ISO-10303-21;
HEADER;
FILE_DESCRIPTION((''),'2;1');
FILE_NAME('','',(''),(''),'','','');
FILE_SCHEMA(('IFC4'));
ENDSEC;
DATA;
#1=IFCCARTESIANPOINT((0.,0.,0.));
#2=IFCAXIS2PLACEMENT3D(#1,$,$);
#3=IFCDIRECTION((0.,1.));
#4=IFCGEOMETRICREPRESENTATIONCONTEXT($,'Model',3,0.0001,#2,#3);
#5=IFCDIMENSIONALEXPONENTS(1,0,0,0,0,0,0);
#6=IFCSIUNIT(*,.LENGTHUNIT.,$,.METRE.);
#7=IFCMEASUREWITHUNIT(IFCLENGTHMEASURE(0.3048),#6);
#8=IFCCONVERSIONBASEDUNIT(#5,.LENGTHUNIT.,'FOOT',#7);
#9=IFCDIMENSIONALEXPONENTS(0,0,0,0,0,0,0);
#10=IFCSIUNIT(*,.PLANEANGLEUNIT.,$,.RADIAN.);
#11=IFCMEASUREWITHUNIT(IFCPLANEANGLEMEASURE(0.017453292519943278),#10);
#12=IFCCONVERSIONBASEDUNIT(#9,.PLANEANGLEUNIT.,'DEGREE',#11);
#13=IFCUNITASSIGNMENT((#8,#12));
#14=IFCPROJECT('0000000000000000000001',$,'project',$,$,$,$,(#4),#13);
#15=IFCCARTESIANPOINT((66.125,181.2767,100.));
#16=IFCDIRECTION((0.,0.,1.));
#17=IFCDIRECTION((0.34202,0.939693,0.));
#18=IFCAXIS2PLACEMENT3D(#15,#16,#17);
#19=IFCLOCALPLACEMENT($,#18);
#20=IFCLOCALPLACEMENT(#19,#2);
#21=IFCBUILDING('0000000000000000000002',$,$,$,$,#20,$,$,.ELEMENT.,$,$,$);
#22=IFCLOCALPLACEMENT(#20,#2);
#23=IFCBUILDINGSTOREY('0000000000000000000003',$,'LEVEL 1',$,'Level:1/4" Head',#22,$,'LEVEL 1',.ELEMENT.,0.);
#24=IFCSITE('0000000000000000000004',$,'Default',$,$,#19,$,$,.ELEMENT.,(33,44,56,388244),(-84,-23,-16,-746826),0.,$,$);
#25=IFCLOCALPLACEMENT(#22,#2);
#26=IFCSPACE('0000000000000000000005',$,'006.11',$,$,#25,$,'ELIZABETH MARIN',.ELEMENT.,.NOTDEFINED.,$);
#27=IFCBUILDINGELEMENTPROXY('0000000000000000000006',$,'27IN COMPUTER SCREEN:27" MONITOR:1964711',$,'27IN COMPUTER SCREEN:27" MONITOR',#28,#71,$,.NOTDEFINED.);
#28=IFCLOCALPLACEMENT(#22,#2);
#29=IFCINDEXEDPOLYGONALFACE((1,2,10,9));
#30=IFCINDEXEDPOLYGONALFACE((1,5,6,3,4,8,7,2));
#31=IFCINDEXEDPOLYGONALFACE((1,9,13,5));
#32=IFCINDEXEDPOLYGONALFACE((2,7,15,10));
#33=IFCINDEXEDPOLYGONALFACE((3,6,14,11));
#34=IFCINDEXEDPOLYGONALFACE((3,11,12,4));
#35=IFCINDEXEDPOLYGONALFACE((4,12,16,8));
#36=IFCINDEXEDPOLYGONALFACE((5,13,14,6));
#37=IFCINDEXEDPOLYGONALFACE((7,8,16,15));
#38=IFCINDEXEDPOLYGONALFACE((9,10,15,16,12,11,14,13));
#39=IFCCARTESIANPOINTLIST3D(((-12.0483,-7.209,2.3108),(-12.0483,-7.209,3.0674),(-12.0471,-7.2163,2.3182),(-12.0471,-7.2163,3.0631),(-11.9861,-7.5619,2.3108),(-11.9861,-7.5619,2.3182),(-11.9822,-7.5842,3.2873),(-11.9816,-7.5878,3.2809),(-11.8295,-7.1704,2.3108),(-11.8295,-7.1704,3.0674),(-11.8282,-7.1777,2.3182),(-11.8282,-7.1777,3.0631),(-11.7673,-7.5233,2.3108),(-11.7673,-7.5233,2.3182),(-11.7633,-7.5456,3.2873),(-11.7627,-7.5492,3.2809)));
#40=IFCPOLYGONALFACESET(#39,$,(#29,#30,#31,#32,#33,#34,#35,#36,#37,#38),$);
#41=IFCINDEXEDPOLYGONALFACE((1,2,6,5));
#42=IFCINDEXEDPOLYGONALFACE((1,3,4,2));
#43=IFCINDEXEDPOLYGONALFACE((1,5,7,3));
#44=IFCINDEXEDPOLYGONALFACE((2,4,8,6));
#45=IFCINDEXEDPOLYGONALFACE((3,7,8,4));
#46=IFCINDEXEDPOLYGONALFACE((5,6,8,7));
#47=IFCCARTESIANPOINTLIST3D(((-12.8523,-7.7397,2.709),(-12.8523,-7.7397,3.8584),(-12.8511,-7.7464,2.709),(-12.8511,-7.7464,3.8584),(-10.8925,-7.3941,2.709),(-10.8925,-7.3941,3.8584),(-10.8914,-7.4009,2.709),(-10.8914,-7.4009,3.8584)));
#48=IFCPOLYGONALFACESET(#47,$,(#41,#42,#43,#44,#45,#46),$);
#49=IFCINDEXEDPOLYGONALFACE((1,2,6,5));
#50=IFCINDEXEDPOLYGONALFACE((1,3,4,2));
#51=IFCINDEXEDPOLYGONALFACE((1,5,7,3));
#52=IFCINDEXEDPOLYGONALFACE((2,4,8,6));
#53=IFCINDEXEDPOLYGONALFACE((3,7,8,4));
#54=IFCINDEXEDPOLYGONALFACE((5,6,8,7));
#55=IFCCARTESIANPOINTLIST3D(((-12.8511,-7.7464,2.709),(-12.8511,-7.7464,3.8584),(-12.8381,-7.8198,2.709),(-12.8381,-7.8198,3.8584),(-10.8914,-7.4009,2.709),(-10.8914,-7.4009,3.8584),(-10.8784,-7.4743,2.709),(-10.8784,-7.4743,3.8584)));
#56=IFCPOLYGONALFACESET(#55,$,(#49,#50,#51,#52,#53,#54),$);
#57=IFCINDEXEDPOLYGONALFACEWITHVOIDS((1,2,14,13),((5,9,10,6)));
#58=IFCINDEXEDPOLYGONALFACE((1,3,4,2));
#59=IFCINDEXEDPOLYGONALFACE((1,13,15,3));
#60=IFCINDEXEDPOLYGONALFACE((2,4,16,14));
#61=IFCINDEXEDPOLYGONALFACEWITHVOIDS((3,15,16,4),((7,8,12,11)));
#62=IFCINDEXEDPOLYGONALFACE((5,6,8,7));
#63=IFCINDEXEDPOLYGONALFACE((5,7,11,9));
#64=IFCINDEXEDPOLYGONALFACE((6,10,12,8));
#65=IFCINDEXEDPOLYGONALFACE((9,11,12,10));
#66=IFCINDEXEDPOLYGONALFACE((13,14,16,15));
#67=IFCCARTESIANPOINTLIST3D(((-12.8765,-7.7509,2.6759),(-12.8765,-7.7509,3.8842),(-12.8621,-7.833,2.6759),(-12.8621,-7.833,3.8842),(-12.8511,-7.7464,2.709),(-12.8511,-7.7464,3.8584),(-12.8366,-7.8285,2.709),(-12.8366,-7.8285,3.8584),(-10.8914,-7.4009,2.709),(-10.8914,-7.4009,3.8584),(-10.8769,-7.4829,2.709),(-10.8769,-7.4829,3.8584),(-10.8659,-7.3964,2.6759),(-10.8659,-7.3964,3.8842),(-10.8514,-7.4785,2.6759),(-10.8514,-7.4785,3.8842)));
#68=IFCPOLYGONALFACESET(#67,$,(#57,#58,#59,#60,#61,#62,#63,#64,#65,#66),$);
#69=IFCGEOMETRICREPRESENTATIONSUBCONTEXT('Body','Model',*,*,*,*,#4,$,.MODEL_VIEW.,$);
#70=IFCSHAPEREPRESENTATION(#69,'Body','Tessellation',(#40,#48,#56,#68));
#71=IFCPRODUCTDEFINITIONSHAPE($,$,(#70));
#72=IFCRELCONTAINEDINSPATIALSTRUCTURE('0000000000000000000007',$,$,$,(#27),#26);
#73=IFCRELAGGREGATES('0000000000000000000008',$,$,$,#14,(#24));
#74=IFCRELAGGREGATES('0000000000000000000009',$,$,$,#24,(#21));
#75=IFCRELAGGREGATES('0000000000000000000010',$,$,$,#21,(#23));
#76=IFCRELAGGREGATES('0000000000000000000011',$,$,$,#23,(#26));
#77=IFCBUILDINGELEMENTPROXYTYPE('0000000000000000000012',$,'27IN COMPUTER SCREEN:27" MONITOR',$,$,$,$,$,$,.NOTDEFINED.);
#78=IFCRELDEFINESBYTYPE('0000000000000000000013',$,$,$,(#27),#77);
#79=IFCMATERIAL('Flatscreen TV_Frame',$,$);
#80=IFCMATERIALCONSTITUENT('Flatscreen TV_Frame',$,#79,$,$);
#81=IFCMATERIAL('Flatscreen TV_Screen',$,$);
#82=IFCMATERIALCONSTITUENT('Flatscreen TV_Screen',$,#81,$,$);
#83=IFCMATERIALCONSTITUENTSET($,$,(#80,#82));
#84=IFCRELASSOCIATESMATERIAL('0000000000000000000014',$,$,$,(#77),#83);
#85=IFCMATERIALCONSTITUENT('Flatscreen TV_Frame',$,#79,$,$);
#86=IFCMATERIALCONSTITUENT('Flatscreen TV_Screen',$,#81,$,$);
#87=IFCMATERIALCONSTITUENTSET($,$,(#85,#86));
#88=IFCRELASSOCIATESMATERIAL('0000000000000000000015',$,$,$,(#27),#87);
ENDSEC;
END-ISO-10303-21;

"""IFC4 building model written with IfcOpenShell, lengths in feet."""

from ifc_helpers import new_model, entity, si_unit, converted_unit, direction, frame, frame_2d, origin, origin_2d_with_axis, place, context, subcontext, project, spatial, polyline, rectangle, outline, extrude, source, transform, mapped, material, constituent, constituent_set, type_object, type_shapes, element, save


model = new_model("IFC4")

# Units and contexts
model_context = context("Model", 3, precision=0.0001, world=origin(), true_north=direction((0.0, 1.0)))
body_context = subcontext(model_context, "Body", "Model", "MODEL_VIEW")
ifc_project = project(units=[converted_unit("LENGTHUNIT", "FOOT", entity("IfcLengthMeasure", 0.3048), si_unit("LENGTHUNIT", "METRE"), dimensions=[1, 0, 0, 0, 0, 0, 0]), converted_unit("PLANEANGLEUNIT", "DEGREE", entity("IfcPlaneAngleMeasure", 0.017453292519943278), si_unit("PLANEANGLEUNIT", "RADIAN"), dimensions=[0, 0, 0, 0, 0, 0, 0])], contexts=[model_context])

# Site, building, storey
site_placement = place(None, frame((66.125, 181.2767, 100.0), z_axis=(0.0, 0.0, 1.0), x_axis=(0.34202, 0.939693, 0.0)))
site = spatial("IfcSite", under=ifc_project, at=site_placement, Name="Default", CompositionType="ELEMENT", RefLatitude=(33, 44, 56, 388244), RefLongitude=(-84, -23, -16, -746826), RefElevation=0.0)
building_placement = place(site_placement, origin())
building = spatial("IfcBuilding", under=site, at=building_placement, CompositionType="ELEMENT")
storey_placement = place(building_placement, origin())
storey = spatial("IfcBuildingStorey", under=building, at=storey_placement, Name="LEVEL 1", ObjectType="Level:1/4\" Head", LongName="LEVEL 1", CompositionType="ELEMENT", Elevation=0.0)

# Shared definitions
space_placement = place(storey_placement, origin())
space = spatial("IfcSpace", under=storey, at=space_placement, Name="006.11", LongName="ELIZABETH MARIN", CompositionType="ELEMENT", PredefinedType="NOTDEFINED")

# Building element proxy
ifc_material_1 = material(Name="Flatscreen TV_Frame")
ifc_constituent_1 = constituent(ifc_material_1, Name="Flatscreen TV_Frame")
ifc_material_2 = material(Name="Flatscreen TV_Screen")
ifc_constituent_2 = constituent(ifc_material_2, Name="Flatscreen TV_Screen")
ifc_constituent_set_1 = constituent_set(constituents=[ifc_constituent_1, ifc_constituent_2])
ifc_constituent_3 = constituent(ifc_material_1, Name="Flatscreen TV_Frame")
ifc_constituent_4 = constituent(ifc_material_2, Name="Flatscreen TV_Screen")
ifc_constituent_set_2 = constituent_set(constituents=[ifc_constituent_3, ifc_constituent_4])
building_element_proxy_type = type_object("IfcBuildingElementProxyType", Name="27IN COMPUTER SCREEN:27\" MONITOR", PredefinedType="NOTDEFINED", material=ifc_constituent_set_2)
shared_shape_1 = source(origin(), body_context, "Body", "SweptSolid", [
    extrude(outline(polyline([(0.3657, -0.4392), (0.3731, -0.4392), (0.3731, 0.0007), (-0.2821, 0.379), (-0.4613, 0.0686), (-0.4548, 0.0649), (-0.2794, 0.3688), (0.3657, -0.0036), (0.3657, -0.4392)])), frame((-0.1111, 0.0264, 0.0687), z_axis=(1.0, 0.0, 0.0), x_axis=(0.0, -0.5, 0.866025)), (0.0, 0.0, 1.0), 0.2222),
    extrude(rectangle(XDim=1.9899, YDim=0.0068, at=origin_2d_with_axis()), frame((0.0, 0.2257, 0.0331), z_axis=(0.0, 0.0, 1.0), x_axis=(-1.0, 0.0, 0.0)), (0.0, 0.0, 1.0), 1.1493),
    extrude(rectangle(XDim=1.9899, YDim=0.0746, at=frame_2d((0.0, 0.0), x_axis=(1.0, 0.0))), frame((0.0, 0.2664, 0.0331), z_axis=(0.0, 0.0, 1.0), x_axis=(-1.0, 0.0, 0.0)), (0.0, 0.0, 1.0), 1.1493),
    extrude(outline(polyline([(-0.6042, -1.0208), (0.6042, -1.0208), (0.6042, 1.0208), (-0.6042, 1.0208), (-0.6042, -1.0208)]), holes=[polyline([(-0.5783, -0.995), (-0.5783, 0.995), (0.571, 0.995), (0.571, -0.995), (-0.5783, -0.995)])]), frame((0.0, 0.2292, 0.6042), z_axis=(0.0, 1.0, 0.0), x_axis=(0.0, 0.0, -1.0)), (0.0, 0.0, 1.0), 0.0833),
])
type_shapes(building_element_proxy_type, [shared_shape_1])
proxy_placement = place(space_placement, frame((-11.911, -7.348, 2.6759), z_axis=(0.0, 0.0, 1.0), x_axis=(-0.984808, -0.173648, 0.0)))
element("IfcBuildingElementProxy", 1, at=proxy_placement, inside=space, type_object=building_element_proxy_type, material=ifc_constituent_set_1, Name="27IN COMPUTER SCREEN:27\" MONITOR:1964711", ObjectType="27IN COMPUTER SCREEN:27\" MONITOR", PredefinedType="NOTDEFINED", context=body_context, shape_type="MappedRepresentation", body=[
    mapped(shared_shape_1, transform((0.0, 0.0, 0.0), scale=1.0)),
])

save(model, "model.ifc")
